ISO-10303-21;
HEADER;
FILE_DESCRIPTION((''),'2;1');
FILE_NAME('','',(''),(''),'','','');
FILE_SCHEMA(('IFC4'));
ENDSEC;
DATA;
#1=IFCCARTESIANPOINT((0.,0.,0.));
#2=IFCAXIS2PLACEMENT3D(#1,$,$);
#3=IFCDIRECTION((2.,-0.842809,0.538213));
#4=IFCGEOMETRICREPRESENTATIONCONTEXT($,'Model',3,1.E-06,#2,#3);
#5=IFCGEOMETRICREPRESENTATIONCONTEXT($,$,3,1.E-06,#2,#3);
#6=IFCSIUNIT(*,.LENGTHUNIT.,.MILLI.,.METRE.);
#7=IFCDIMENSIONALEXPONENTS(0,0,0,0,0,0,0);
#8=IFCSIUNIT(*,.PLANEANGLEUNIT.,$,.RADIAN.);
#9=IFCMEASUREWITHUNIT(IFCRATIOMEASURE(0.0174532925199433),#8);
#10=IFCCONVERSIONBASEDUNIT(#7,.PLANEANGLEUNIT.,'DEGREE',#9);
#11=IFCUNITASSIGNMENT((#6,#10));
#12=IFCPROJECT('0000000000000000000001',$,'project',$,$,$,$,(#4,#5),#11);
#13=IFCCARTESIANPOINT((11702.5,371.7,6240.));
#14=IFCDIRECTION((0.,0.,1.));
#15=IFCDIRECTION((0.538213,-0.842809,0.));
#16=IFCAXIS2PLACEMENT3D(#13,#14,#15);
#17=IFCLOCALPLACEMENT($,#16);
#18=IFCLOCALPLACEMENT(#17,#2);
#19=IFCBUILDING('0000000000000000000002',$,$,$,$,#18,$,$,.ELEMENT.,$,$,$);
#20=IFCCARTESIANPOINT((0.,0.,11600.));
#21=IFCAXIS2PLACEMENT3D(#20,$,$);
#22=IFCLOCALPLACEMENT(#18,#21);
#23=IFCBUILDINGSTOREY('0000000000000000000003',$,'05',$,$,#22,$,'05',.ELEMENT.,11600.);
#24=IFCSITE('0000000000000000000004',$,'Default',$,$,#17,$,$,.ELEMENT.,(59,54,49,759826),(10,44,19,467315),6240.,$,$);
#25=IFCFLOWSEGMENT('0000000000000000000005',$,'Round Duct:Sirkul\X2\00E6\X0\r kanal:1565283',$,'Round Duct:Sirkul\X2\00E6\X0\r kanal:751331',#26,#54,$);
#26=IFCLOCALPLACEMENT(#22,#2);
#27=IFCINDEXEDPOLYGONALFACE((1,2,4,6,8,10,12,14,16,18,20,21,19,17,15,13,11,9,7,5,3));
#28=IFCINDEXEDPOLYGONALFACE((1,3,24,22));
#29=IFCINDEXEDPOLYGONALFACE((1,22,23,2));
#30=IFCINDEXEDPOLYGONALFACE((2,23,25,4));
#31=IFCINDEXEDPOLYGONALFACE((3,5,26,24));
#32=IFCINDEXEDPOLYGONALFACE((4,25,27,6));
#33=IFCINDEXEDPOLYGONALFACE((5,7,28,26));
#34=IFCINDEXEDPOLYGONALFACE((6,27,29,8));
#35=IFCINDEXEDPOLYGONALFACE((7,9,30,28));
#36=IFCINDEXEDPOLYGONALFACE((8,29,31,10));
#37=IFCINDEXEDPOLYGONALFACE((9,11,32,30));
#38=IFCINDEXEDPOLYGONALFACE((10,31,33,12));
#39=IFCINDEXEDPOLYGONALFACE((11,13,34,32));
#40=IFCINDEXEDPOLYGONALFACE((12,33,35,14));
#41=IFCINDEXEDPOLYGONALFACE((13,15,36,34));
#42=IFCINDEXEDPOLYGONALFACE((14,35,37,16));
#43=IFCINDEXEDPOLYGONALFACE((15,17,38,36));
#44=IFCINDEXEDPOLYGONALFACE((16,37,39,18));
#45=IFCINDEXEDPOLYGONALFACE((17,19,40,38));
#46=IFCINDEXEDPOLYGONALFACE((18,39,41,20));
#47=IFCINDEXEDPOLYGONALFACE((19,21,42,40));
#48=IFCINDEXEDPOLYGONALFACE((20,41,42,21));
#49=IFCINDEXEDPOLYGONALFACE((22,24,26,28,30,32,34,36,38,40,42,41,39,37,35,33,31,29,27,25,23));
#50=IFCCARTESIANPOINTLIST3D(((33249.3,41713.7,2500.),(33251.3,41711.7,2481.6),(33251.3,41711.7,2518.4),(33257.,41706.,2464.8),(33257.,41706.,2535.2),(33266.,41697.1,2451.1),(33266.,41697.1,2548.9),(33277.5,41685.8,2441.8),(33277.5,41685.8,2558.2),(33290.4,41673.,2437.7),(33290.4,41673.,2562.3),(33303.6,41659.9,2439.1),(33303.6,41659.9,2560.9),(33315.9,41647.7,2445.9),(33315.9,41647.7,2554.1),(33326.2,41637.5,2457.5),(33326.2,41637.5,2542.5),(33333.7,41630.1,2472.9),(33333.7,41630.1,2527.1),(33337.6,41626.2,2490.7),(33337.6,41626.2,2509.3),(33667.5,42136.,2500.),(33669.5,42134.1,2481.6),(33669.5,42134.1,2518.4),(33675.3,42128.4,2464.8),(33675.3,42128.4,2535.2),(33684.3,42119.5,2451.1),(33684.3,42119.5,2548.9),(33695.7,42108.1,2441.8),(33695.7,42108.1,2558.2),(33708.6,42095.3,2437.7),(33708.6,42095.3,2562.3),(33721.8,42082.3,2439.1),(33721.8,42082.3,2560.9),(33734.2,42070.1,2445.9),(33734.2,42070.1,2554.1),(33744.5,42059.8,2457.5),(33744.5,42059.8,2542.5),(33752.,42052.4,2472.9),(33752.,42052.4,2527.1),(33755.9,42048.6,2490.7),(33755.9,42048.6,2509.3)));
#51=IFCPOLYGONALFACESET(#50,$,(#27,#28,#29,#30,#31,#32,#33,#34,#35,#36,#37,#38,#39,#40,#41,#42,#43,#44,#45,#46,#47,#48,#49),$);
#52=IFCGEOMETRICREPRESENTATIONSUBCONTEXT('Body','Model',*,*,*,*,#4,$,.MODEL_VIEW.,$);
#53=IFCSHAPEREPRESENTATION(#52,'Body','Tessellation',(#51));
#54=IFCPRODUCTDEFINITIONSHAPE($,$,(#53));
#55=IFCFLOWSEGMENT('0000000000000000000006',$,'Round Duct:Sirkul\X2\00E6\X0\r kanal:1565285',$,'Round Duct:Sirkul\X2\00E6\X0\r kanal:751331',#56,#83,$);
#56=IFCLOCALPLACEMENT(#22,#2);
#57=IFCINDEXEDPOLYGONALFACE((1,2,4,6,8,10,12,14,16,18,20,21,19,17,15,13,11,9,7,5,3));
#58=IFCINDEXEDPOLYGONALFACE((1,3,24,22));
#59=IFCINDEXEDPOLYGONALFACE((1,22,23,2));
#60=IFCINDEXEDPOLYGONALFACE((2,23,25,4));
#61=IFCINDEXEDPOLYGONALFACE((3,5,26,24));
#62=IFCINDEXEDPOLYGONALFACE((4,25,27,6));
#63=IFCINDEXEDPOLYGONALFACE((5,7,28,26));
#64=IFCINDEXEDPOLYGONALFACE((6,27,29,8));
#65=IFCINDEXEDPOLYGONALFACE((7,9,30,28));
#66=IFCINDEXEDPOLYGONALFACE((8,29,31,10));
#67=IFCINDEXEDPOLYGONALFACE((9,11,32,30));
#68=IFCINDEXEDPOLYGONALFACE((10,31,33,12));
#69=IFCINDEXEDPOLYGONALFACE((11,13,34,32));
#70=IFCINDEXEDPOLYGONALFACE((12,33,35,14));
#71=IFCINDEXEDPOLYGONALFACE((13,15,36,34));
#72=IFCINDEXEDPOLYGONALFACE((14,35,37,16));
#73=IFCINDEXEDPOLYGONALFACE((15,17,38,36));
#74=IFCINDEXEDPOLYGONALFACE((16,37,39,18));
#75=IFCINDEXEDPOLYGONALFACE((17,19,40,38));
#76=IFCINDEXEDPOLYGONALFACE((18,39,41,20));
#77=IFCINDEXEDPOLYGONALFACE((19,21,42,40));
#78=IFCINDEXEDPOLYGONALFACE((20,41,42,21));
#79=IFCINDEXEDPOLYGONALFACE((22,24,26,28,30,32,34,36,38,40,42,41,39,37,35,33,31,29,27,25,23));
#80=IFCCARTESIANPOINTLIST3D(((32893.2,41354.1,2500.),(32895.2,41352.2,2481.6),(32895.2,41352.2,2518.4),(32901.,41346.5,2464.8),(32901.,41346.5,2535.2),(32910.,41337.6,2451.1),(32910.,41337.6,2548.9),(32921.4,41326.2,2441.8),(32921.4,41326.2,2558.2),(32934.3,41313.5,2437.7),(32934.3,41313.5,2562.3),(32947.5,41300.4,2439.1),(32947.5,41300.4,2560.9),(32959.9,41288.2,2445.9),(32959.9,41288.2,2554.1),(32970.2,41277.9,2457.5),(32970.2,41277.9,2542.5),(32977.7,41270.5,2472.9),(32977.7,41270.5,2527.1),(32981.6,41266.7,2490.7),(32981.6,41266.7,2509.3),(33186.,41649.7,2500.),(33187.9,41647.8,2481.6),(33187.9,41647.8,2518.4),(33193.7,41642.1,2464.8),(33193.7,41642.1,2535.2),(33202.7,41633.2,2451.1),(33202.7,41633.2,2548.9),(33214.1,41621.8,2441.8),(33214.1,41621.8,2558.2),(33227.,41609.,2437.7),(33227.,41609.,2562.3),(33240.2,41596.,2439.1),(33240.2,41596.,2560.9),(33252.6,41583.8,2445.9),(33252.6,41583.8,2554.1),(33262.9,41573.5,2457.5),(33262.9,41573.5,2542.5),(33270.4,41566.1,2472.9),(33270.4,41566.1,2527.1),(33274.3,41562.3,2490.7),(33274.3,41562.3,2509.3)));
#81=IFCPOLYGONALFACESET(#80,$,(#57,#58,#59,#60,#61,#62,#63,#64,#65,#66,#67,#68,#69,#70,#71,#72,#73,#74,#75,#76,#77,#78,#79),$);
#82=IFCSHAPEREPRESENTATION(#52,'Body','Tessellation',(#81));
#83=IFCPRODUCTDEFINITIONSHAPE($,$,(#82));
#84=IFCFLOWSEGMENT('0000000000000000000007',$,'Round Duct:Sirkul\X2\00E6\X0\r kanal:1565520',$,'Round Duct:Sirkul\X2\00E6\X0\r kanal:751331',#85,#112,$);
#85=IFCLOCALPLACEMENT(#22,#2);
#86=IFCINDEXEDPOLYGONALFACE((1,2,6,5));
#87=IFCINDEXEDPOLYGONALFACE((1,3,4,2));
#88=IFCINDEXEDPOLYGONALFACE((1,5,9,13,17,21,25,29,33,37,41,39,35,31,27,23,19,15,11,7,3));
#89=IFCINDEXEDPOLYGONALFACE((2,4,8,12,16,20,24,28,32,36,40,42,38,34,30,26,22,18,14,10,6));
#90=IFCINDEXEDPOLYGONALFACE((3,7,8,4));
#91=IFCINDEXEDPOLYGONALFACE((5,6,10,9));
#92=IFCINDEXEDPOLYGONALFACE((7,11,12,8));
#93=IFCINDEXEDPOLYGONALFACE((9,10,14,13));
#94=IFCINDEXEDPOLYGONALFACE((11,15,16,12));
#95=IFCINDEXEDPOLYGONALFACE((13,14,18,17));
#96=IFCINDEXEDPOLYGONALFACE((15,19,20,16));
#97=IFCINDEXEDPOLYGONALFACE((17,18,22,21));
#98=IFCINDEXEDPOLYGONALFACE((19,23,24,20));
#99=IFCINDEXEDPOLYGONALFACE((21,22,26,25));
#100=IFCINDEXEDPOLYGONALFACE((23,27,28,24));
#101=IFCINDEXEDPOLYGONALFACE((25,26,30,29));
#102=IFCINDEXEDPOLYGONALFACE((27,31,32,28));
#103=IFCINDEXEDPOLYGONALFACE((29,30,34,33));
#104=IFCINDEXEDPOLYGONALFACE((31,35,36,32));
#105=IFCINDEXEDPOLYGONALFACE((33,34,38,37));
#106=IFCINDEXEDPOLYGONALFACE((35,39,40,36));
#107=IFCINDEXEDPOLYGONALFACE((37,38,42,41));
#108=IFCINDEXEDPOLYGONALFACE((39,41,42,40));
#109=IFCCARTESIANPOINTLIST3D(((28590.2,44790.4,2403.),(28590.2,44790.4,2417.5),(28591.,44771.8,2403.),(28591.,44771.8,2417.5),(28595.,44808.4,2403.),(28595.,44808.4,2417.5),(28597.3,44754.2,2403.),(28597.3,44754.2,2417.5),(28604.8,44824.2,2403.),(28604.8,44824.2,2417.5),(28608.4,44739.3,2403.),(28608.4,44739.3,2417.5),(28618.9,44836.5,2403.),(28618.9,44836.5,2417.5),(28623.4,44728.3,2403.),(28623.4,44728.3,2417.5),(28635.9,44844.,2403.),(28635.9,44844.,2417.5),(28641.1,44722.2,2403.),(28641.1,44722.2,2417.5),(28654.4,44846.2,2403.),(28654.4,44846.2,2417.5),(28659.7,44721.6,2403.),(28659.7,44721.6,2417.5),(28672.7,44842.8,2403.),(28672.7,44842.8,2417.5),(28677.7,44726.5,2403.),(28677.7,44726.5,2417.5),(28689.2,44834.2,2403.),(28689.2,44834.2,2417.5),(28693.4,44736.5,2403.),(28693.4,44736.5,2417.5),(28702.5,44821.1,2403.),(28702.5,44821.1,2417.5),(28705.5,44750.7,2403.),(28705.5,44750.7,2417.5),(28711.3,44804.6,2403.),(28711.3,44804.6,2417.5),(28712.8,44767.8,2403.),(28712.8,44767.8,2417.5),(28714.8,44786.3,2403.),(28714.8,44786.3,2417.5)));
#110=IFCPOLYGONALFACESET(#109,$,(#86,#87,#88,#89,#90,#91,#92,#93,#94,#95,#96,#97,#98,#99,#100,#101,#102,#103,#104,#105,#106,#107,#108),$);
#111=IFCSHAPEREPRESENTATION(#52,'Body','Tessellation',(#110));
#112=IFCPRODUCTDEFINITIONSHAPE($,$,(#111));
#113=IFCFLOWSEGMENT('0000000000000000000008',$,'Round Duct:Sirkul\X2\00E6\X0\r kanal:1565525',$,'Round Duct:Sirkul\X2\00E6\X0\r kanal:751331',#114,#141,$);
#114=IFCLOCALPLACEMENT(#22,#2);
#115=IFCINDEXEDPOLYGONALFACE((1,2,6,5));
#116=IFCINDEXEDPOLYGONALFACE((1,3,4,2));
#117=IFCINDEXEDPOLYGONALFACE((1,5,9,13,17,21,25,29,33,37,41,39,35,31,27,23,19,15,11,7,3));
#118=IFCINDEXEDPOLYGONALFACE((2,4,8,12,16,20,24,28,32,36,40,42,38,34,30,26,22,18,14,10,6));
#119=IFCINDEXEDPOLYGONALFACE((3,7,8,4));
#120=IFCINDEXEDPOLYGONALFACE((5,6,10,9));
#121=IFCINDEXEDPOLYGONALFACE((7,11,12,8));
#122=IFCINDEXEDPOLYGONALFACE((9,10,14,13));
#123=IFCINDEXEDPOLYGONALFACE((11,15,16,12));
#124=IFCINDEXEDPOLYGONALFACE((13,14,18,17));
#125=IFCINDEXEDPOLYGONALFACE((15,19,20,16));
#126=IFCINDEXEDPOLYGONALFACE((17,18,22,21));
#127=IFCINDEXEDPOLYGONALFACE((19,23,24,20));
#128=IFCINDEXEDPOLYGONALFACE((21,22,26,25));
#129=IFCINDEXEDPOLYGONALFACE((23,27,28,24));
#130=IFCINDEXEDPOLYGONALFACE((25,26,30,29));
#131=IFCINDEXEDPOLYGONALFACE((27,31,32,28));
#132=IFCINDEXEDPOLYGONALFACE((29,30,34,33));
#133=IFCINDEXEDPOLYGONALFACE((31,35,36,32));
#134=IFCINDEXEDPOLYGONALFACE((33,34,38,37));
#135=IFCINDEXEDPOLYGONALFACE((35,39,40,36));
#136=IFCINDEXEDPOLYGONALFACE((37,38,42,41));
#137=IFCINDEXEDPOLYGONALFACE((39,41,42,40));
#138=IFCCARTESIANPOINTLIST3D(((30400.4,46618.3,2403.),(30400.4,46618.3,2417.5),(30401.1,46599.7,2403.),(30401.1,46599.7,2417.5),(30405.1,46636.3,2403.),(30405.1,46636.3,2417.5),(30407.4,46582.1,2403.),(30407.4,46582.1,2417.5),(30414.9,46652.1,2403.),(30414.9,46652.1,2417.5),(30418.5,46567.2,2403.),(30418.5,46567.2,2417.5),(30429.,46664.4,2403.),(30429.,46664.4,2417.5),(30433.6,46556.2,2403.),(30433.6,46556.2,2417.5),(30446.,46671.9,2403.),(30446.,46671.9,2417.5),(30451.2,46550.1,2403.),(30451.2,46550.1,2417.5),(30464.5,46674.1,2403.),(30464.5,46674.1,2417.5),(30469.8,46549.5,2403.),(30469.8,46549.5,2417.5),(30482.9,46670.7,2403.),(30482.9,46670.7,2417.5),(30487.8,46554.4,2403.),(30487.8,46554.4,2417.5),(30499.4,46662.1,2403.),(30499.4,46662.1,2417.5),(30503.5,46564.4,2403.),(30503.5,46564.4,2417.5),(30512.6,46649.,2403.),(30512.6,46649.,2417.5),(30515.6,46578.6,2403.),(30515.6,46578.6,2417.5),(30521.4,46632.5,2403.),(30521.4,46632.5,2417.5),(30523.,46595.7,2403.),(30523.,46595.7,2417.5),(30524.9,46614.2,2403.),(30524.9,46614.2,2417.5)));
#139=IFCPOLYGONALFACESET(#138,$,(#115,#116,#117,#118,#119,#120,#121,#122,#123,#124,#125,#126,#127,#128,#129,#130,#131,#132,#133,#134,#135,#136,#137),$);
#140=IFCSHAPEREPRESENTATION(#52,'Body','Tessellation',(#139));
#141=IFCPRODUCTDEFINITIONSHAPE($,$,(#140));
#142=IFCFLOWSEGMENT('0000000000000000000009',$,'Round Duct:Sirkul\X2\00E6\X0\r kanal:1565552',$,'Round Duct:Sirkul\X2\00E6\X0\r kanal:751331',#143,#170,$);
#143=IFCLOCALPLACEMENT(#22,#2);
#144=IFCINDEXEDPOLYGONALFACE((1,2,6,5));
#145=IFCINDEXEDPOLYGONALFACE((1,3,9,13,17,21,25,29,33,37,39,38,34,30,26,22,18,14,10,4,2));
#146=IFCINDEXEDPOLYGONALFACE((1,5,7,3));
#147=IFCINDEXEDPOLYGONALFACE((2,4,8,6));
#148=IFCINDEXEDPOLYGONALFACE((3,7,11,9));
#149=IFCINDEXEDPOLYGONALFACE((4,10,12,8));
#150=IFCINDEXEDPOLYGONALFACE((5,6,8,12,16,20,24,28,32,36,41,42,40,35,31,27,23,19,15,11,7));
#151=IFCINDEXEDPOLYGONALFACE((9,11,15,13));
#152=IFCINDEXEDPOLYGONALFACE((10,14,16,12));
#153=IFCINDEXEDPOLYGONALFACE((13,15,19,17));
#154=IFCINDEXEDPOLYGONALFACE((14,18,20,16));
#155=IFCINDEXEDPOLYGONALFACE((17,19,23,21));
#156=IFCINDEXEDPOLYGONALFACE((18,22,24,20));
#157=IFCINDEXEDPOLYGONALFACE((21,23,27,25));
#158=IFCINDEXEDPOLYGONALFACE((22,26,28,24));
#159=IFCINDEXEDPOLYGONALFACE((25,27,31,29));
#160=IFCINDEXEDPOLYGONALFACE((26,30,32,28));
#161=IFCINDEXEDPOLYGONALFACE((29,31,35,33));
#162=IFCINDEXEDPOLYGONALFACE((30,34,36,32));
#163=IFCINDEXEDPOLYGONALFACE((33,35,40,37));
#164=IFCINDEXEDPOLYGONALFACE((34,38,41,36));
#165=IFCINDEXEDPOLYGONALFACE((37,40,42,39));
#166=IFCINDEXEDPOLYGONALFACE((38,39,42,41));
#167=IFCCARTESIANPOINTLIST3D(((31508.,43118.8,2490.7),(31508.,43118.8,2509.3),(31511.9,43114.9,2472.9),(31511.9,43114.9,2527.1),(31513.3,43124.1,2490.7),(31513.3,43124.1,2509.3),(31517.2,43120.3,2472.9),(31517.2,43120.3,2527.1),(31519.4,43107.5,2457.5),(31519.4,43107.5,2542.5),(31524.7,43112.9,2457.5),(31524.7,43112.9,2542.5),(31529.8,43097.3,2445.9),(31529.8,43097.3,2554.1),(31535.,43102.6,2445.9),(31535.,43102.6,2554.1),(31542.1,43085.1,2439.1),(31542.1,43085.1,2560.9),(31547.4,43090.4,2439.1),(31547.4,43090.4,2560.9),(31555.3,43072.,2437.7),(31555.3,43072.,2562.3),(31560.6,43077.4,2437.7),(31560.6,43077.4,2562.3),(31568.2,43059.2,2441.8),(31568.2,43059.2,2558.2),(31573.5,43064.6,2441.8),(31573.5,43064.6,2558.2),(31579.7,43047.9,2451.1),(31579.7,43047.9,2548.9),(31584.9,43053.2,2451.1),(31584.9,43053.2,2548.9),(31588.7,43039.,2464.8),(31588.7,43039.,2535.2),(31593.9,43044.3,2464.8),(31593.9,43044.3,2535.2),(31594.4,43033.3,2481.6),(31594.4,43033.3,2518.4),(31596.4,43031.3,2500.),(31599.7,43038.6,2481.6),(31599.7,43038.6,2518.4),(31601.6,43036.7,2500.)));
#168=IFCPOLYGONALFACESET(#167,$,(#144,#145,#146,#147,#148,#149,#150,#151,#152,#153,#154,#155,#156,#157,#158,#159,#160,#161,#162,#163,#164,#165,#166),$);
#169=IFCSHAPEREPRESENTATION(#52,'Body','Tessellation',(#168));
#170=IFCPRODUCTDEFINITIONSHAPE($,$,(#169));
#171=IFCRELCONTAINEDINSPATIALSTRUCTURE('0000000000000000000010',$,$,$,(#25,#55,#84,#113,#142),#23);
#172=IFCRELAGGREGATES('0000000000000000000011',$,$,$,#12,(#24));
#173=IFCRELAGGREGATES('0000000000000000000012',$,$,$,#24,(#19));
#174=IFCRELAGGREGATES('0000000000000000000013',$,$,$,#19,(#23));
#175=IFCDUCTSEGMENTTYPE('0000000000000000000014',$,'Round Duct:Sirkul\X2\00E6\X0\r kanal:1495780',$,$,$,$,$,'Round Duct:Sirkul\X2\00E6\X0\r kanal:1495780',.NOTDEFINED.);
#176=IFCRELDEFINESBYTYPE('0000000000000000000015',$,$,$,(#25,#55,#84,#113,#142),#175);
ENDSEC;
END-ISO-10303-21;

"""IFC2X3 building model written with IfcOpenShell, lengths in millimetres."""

from ifc_helpers import new_model, entity, si_unit, converted_unit, direction, frame, frame_2d, origin, origin_2d_with_axis, place, context, subcontext, project, spatial, circle, extrude, type_object, element, save


model = new_model("IFC2X3")

# Units and contexts
model_context = context("Model", 3, precision=1e-06, world=origin(), true_north=direction((2.0, -0.842809, 0.538213)))
context_of_model = context(None, 3, precision=1e-06, world=origin(), true_north=direction((2.0, -0.842809, 0.538213)))
body_context = subcontext(model_context, "Body", "Model", "MODEL_VIEW")
ifc_project = project(units=[si_unit("LENGTHUNIT", "METRE", prefix="MILLI"), converted_unit("PLANEANGLEUNIT", "DEGREE", entity("IfcRatioMeasure", 0.0174532925199433), si_unit("PLANEANGLEUNIT", "RADIAN"), dimensions=[0, 0, 0, 0, 0, 0, 0])], contexts=[model_context, context_of_model])

# Site, building, storey
site_placement = place(None, frame((11702.5, 371.7, 6240.0), z_axis=(0.0, 0.0, 1.0), x_axis=(0.538213, -0.842809, 0.0)))
site = spatial("IfcSite", under=ifc_project, at=site_placement, Name="Default", CompositionType="ELEMENT", RefLatitude=(59, 54, 49, 759826), RefLongitude=(10, 44, 19, 467315), RefElevation=6240.0)
building_placement = place(site_placement, origin())
building = spatial("IfcBuilding", under=site, at=building_placement, CompositionType="ELEMENT")
storey_placement = place(building_placement, frame((0.0, 0.0, 11600.0)))
storey = spatial("IfcBuildingStorey", under=building, at=storey_placement, Name="05", LongName="05", CompositionType="ELEMENT", Elevation=11600.0)

# Flow segments
duct_segment_type = type_object("IfcDuctSegmentType", Name="Round Duct:Sirkulær kanal:1495780", ElementType="Round Duct:Sirkulær kanal:1495780", PredefinedType="NOTDEFINED")
flow_segment_1_placement = place(storey_placement, origin())
element("IfcFlowSegment", 1, at=flow_segment_1_placement, inside=storey, type_object=duct_segment_type, Name="Round Duct:Sirkulær kanal:1565283", ObjectType="Round Duct:Sirkulær kanal:751331", context=body_context, shape_type="SweptSolid", body=[
    extrude(circle(Radius=62.5, at=origin_2d_with_axis()), frame((33293.7, 41669.7, 2500.0), z_axis=(0.703643, 0.710554, 0.0), x_axis=(-0.710554, 0.703643, 0.0)), (0.0, 0.0, 1.0), 594.4),
])
flow_segment_2_placement = place(storey_placement, origin())
element("IfcFlowSegment", 2, at=flow_segment_2_placement, inside=storey, type_object=duct_segment_type, Name="Round Duct:Sirkulær kanal:1565285", ObjectType="Round Duct:Sirkulær kanal:751331", context=body_context, shape_type="SweptSolid", body=[
    extrude(circle(Radius=62.5, at=origin_2d_with_axis()), frame((32937.7, 41310.2, 2500.0), z_axis=(0.703643, 0.710554, 0.0), x_axis=(-0.710554, 0.703643, 0.0)), (0.0, 0.0, 1.0), 416.0),
])
flow_segment_3_placement = place(storey_placement, origin())
element("IfcFlowSegment", 3, at=flow_segment_3_placement, inside=storey, type_object=duct_segment_type, Name="Round Duct:Sirkulær kanal:1565520", ObjectType="Round Duct:Sirkulær kanal:751331", context=body_context, shape_type="SweptSolid", body=[
    extrude(circle(Radius=62.5, at=frame_2d((0.0, 0.0), x_axis=(1.0, 0.0))), frame((28652.4, 44783.7, 2403.0), z_axis=(0.0, 0.0, 1.0), x_axis=(-0.703643, -0.710554, 0.0)), (0.0, 0.0, 1.0), 14.5),
])
flow_segment_4_placement = place(storey_placement, origin())
element("IfcFlowSegment", 4, at=flow_segment_4_placement, inside=storey, type_object=duct_segment_type, Name="Round Duct:Sirkulær kanal:1565525", ObjectType="Round Duct:Sirkulær kanal:751331", context=body_context, shape_type="SweptSolid", body=[
    extrude(circle(Radius=62.5, at=frame_2d((0.0, 0.0), x_axis=(1.0, 0.0))), frame((30462.5, 46611.6, 2403.0), z_axis=(0.0, 0.0, 1.0), x_axis=(-0.703643, -0.710554, 0.0)), (0.0, 0.0, 1.0), 14.5),
])
flow_segment_5_placement = place(storey_placement, origin())
element("IfcFlowSegment", 5, at=flow_segment_5_placement, inside=storey, type_object=duct_segment_type, Name="Round Duct:Sirkulær kanal:1565552", ObjectType="Round Duct:Sirkulær kanal:751331", context=body_context, shape_type="SweptSolid", body=[
    extrude(circle(Radius=62.5, at=origin_2d_with_axis()), frame((31552.0, 43075.3, 2500.0), z_axis=(0.703643, 0.710554, 0.0), x_axis=(0.710554, -0.703643, 0.0)), (0.0, 0.0, 1.0), 7.5),
])

save(model, "model.ifc")
